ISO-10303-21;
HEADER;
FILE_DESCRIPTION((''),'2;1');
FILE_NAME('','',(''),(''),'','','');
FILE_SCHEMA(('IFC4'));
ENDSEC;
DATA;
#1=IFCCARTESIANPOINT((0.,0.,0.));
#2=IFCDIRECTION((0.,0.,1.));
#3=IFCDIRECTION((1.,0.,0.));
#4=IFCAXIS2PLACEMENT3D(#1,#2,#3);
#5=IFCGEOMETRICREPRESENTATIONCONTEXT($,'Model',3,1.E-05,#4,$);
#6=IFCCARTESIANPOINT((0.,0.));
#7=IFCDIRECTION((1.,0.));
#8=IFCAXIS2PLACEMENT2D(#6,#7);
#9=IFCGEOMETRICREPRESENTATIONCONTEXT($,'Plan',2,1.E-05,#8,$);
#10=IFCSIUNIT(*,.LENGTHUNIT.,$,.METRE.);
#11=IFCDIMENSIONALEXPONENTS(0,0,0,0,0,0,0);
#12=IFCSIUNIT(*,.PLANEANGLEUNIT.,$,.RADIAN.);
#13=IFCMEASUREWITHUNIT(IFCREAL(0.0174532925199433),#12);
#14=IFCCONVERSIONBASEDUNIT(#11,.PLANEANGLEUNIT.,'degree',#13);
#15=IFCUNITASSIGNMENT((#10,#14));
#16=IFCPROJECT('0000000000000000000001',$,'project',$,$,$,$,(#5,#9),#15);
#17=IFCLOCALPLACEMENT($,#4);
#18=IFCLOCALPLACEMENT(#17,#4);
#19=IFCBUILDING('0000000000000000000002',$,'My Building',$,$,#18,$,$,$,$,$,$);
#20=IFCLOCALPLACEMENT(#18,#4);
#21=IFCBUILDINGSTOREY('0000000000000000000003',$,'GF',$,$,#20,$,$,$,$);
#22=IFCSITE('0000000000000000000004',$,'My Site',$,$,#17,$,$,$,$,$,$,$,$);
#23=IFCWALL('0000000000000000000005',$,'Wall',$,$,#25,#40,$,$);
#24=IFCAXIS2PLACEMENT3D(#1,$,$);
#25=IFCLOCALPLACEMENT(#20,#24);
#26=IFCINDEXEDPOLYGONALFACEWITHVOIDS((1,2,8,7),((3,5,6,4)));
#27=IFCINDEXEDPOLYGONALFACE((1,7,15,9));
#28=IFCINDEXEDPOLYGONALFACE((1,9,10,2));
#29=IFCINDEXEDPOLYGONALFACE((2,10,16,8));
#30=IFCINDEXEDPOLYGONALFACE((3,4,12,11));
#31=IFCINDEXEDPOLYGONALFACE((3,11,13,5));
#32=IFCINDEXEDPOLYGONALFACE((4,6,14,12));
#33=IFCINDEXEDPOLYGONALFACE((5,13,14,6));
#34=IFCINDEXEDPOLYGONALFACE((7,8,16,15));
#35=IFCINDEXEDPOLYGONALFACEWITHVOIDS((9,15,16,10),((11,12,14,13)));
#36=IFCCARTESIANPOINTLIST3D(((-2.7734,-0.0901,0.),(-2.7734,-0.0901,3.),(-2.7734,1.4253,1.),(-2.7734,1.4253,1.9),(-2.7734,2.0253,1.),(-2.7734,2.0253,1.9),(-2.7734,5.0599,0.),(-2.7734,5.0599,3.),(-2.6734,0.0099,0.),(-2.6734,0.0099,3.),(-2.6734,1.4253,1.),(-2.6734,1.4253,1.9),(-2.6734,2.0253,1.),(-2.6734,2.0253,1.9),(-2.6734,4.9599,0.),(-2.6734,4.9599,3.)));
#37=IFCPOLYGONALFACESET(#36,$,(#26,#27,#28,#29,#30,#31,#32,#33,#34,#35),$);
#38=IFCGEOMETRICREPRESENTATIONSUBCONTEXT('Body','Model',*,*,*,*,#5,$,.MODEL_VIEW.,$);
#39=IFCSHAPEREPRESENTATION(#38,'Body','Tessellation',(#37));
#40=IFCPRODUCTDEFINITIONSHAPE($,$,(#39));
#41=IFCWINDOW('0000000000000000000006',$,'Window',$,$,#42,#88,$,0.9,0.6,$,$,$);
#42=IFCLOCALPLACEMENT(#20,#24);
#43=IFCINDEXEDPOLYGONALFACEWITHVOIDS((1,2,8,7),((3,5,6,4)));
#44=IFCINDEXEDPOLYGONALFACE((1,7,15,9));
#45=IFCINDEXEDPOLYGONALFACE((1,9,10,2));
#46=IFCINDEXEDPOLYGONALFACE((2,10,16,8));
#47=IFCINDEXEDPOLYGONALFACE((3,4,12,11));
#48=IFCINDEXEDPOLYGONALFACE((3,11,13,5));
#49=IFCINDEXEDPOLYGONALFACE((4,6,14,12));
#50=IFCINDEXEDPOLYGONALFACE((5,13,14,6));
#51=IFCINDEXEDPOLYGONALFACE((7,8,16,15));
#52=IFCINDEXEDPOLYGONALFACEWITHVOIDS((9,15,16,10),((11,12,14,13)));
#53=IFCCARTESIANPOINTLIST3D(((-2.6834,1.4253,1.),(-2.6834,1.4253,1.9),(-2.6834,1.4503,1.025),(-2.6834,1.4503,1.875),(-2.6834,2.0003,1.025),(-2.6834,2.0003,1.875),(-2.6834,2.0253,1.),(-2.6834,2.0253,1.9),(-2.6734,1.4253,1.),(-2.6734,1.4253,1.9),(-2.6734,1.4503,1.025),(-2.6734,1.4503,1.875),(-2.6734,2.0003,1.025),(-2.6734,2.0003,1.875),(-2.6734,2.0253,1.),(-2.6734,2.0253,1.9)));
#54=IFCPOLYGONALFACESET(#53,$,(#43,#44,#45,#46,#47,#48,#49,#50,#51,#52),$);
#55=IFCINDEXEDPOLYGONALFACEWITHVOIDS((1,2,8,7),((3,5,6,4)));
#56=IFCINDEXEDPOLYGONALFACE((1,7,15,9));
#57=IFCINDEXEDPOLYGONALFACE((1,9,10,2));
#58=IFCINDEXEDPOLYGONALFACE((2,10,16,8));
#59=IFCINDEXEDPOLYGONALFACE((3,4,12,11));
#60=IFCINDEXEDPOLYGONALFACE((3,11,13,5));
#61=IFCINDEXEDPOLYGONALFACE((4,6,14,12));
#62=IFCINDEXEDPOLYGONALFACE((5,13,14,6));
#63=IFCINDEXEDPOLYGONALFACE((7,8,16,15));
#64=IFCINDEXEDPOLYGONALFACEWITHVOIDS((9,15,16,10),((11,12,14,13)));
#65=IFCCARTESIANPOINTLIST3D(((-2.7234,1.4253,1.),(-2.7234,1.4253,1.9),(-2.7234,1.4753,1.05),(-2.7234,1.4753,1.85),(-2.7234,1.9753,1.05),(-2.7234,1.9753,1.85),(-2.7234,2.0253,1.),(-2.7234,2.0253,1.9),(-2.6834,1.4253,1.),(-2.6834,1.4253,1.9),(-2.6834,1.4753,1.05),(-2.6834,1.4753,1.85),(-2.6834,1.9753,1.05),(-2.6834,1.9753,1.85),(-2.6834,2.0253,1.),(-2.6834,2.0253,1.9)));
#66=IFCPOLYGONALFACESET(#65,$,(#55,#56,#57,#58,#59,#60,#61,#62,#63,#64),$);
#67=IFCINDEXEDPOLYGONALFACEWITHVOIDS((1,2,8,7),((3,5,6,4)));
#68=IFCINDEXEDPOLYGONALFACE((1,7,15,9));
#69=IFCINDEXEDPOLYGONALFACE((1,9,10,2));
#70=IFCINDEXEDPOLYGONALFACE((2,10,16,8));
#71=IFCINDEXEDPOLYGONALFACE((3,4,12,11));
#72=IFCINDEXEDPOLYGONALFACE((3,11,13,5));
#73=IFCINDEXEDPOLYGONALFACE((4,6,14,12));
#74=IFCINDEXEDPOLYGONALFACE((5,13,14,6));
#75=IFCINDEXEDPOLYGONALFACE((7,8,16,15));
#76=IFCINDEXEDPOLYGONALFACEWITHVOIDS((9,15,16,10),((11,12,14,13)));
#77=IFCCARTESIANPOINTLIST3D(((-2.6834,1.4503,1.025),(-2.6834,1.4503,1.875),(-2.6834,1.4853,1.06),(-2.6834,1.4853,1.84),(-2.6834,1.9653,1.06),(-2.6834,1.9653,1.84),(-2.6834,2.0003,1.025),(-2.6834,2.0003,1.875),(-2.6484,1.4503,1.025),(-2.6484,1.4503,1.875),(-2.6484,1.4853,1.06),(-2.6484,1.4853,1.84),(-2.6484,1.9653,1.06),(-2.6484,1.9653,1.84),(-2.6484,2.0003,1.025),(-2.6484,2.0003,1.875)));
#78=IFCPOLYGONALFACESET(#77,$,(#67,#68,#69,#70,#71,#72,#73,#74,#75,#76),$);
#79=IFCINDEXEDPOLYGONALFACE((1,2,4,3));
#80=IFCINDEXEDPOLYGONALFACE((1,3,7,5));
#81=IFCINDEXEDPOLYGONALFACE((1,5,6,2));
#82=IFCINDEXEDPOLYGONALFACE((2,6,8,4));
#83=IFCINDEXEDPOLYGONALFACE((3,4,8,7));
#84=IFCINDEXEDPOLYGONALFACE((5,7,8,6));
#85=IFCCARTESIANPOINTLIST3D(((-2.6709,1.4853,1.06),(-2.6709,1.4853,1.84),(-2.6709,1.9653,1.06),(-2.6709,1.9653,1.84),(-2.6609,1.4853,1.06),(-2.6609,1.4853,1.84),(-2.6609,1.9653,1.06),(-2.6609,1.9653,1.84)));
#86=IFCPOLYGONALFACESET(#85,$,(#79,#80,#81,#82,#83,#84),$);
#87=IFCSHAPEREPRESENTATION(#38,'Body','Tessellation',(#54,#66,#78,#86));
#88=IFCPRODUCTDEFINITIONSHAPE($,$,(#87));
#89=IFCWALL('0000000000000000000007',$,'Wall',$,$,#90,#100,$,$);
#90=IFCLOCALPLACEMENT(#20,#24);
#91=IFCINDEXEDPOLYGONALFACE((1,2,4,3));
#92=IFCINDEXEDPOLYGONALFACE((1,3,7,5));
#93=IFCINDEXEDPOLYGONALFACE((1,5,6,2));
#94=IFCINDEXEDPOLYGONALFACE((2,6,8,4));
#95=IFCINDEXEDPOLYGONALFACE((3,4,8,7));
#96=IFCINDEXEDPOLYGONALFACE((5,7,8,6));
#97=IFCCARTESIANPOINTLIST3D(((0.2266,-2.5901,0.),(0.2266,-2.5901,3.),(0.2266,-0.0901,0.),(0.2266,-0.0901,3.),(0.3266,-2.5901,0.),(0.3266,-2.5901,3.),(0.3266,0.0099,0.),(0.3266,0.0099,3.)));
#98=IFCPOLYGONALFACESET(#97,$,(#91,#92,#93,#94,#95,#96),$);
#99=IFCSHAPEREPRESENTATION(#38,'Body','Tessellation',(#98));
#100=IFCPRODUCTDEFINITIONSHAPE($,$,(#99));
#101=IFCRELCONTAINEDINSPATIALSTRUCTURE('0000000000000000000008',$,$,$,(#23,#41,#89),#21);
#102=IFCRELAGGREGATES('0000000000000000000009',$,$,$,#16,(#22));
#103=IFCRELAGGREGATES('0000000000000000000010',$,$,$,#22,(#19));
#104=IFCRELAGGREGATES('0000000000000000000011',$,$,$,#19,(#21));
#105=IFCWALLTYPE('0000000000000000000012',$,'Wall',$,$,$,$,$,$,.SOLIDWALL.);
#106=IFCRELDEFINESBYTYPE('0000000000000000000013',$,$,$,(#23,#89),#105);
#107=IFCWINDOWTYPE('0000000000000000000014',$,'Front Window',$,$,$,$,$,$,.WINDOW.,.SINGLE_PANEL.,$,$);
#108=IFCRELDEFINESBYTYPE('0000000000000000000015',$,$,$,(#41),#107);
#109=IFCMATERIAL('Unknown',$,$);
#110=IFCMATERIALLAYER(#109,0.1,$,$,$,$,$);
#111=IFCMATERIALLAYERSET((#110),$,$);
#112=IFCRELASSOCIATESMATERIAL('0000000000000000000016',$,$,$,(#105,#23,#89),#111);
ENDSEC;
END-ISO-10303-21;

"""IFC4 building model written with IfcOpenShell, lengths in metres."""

from ifc_helpers import new_model, entity, si_unit, converted_unit, frame, origin_with_axes, origin_2d_with_axis, place, context, subcontext, project, spatial, line, indexed_curve, outline, extrude, shape, source, transform, mapped, material, layer, layer_set, layer_usage, type_object, type_shapes, element, fill, save


model = new_model("IFC4")

# Units and contexts
model_context = context("Model", 3, precision=1e-05, world=origin_with_axes())
plan_context = context("Plan", 2, precision=1e-05, world=origin_2d_with_axis())
body_context_1 = subcontext(model_context, "Body", "Model", "MODEL_VIEW")
body_context_2 = subcontext(plan_context, "Body", "Plan", "PLAN_VIEW")
ifc_project = project(units=[si_unit("LENGTHUNIT", "METRE"), converted_unit("PLANEANGLEUNIT", "degree", entity("IfcReal", 0.0174532925199433), si_unit("PLANEANGLEUNIT", "RADIAN"), dimensions=[0, 0, 0, 0, 0, 0, 0])], contexts=[model_context, plan_context])

# Site, building, storey
site_placement = place(None, origin_with_axes())
site = spatial("IfcSite", under=ifc_project, at=site_placement, Name="My Site")
building_placement = place(site_placement, origin_with_axes())
building = spatial("IfcBuilding", under=site, at=building_placement, Name="My Building")
storey_placement = place(building_placement, origin_with_axes())
storey = spatial("IfcBuildingStorey", under=building, at=storey_placement, Name="GF")

# Shared definitions
ifc_material_1 = material(Name="Unknown")

# Shared definitions
ifc_layer_1 = layer(ifc_material_1, 0.1)
ifc_layer_set_1 = layer_set([ifc_layer_1])
wall_type = type_object("IfcWallType", Name="Wall", PredefinedType="SOLIDWALL", material=ifc_layer_set_1)
shared_shape_1 = source(origin_with_axes(), body_context_1, "Body", "SweptSolid", [
    extrude(outline(indexed_curve([(0.0, 0.0), (0.6, 0.0), (0.6, 0.9), (0.0, 0.9)], segments=[line(1, 2, 3, 4, 1)])), frame((0.0, -0.6, 0.0), z_axis=(0.0, -1.0, 0.0), x_axis=(1.0, 0.0, 0.0)), (0.0, 0.0, -1.0), 1.2),
])
window_type_1 = type_object("IfcWindowType", Name="Front Window", PartitioningType="SINGLE_PANEL", PredefinedType="WINDOW")
shared_shape_2 = source(origin_with_axes(), body_context_1, "Body", "SweptSolid", [
    extrude(outline(indexed_curve([(0.0, 0.0), (0.6, 0.0), (0.6, 0.9), (0.0, 0.9)], segments=[line(1, 2, 3, 4, 1)]), holes=[indexed_curve([(0.025, 0.025), (0.575, 0.025), (0.575, 0.875), (0.025, 0.875)], segments=[line(1, 2, 3, 4, 1)])]), frame((0.0, 0.09, 0.0), z_axis=(0.0, -1.0, 0.0), x_axis=(1.0, 0.0, 0.0)), (0.0, 0.0, -1.0), 0.01),
    extrude(outline(indexed_curve([(0.0, 0.0), (0.6, 0.0), (0.6, 0.9), (0.0, 0.9)], segments=[line(1, 2, 3, 4, 1)]), holes=[indexed_curve([(0.05, 0.05), (0.55, 0.05), (0.55, 0.85), (0.05, 0.85)], segments=[line(1, 2, 3, 4, 1)])]), frame((0.0, 0.05, 0.0), z_axis=(0.0, -1.0, 0.0), x_axis=(1.0, 0.0, 0.0)), (0.0, 0.0, -1.0), 0.04),
    extrude(outline(indexed_curve([(0.0, 0.0), (0.55, 0.0), (0.55, 0.85), (0.0, 0.85)], segments=[line(1, 2, 3, 4, 1)]), holes=[indexed_curve([(0.035, 0.035), (0.515, 0.035), (0.515, 0.815), (0.035, 0.815)], segments=[line(1, 2, 3, 4, 1)])]), frame((0.025, 0.09, 0.025), z_axis=(0.0, -1.0, 0.0), x_axis=(1.0, 0.0, 0.0)), (0.0, 0.0, -1.0), 0.035),
    extrude(outline(indexed_curve([(0.035, 0.035), (0.515, 0.035), (0.515, 0.815), (0.035, 0.815)], segments=[line(1, 2, 3, 4, 1)])), frame((0.025, 0.1025, 0.025), z_axis=(0.0, -1.0, 0.0), x_axis=(1.0, 0.0, 0.0)), (0.0, 0.0, -1.0), 0.01),
])
shared_shape_3 = source(origin_with_axes(), body_context_2, "Body", "Curve2D", [
    entity("IfcIndexedPolyCurve", entity("IfcCartesianPointList2D", [[0.05, 0.05], [0.55, 0.05]])),
    entity("IfcIndexedPolyCurve", entity("IfcCartesianPointList2D", [[0.0, 0.1], [0.025, 0.1], [0.025, 0.09], [0.05, 0.09], [0.05, 0.05], [0.0, 0.05]]), [entity("IfcLineIndex", [1, 2, 3, 4, 5, 6, 1])]),
    entity("IfcIndexedPolyCurve", entity("IfcCartesianPointList2D", [[0.6, 0.1], [0.575, 0.1], [0.575, 0.09], [0.55, 0.09], [0.55, 0.05], [0.6, 0.05]]), [entity("IfcLineIndex", [1, 2, 3, 4, 5, 6, 1])]),
    entity("IfcIndexedPolyCurve", entity("IfcCartesianPointList2D", [[0.025, 0.09], [0.06, 0.09], [0.06, 0.125], [0.025, 0.125]]), [entity("IfcLineIndex", [1, 2, 3, 4, 1])]),
    entity("IfcIndexedPolyCurve", entity("IfcCartesianPointList2D", [[0.575, 0.09], [0.54, 0.09], [0.54, 0.125], [0.575, 0.125]]), [entity("IfcLineIndex", [1, 2, 3, 4, 1])]),
    entity("IfcIndexedPolyCurve", entity("IfcCartesianPointList2D", [[0.06, 0.09], [0.54, 0.09]])),
    entity("IfcIndexedPolyCurve", entity("IfcCartesianPointList2D", [[0.06, 0.125], [0.54, 0.125]])),
    entity("IfcIndexedPolyCurve", entity("IfcCartesianPointList2D", [[0.06, 0.1075], [0.54, 0.1075]])),
])
type_shapes(window_type_1, [shared_shape_2, shared_shape_3])

# Wall, opening, window
ifc_layer_usage_1 = layer_usage(ifc_layer_set_1, "AXIS2", "POSITIVE", 0.0)
wall_1_placement = place(storey_placement, frame((-2.7734, 5.0599, 0.0), z_axis=(0.0, 0.0, 1.0), x_axis=(0.0, -1.0, 0.0)))
wall_1 = element("IfcWall", 1, at=wall_1_placement, inside=storey, type_object=wall_type, material=ifc_layer_usage_1, Name="Wall", context=body_context_1, shape_type="SweptSolid", body=[
    extrude(outline(indexed_curve([(0.0, 0.0), (0.1, 0.1), (5.05, 0.1), (5.15, 0.0)], segments=[line(1, 2, 3, 4, 1)])), origin_with_axes(), (0.0, 0.0, 1.0), 3.0),
])
opening_1_placement = place(wall_1_placement, frame((3.0346, 0.0, 1.0), z_axis=(0.0, 0.0, 1.0), x_axis=(1.0, 0.0, 0.0)))
opening_1 = element("IfcOpeningElement", 2, at=opening_1_placement, cuts=wall_1, PredefinedType="OPENING", context=body_context_1, shape_type="MappedRepresentation", body=[
    mapped(shared_shape_1, transform((0.0, 0.0, 0.0), x_axis=(1.0, 0.0, 0.0), y_axis=(0.0, 1.0, 0.0), z_axis=(0.0, 0.0, 1.0), scale=1.0)),
])
window_1_placement = place(opening_1_placement, frame((0.0, 0.0, 0.0), z_axis=(0.0, 0.0, 1.0), x_axis=(1.0, 0.0, 0.0)))
window_1 = element("IfcWindow", 3, at=window_1_placement, inside=storey, type_object=window_type_1, Name="Window", OverallHeight=0.9, OverallWidth=0.6, shapes=[
    shape(body_context_1, "Body", "MappedRepresentation", [mapped(shared_shape_2, transform((0.0, 0.0, 0.0), x_axis=(1.0, 0.0, 0.0), y_axis=(0.0, 1.0, 0.0), z_axis=(0.0, 0.0, 1.0), scale=1.0))]),
    shape(body_context_2, "Body", "MappedRepresentation", [mapped(shared_shape_3, transform((0.0, 0.0, 0.0), x_axis=(1.0, 0.0, 0.0), y_axis=(0.0, 1.0, 0.0), z_axis=(0.0, 0.0, 1.0), scale=1.0))]),
])
fill(opening_1, window_1)

# Wall
ifc_layer_usage_2 = layer_usage(ifc_layer_set_1, "AXIS2", "POSITIVE", 0.0)
wall_2_placement = place(storey_placement, frame((0.2266, -0.0901, 0.0), z_axis=(0.0, 0.0, 1.0), x_axis=(0.0, -1.0, 0.0)))
element("IfcWall", 4, at=wall_2_placement, inside=storey, type_object=wall_type, material=ifc_layer_usage_2, Name="Wall", context=body_context_1, shape_type="SweptSolid", body=[
    extrude(outline(indexed_curve([(0.0, 0.0), (-0.1, 0.1), (2.5, 0.1), (2.5, 0.0)], segments=[line(1, 2, 3, 4, 1)])), origin_with_axes(), (0.0, 0.0, 1.0), 3.0),
])

save(model, "model.ifc")
